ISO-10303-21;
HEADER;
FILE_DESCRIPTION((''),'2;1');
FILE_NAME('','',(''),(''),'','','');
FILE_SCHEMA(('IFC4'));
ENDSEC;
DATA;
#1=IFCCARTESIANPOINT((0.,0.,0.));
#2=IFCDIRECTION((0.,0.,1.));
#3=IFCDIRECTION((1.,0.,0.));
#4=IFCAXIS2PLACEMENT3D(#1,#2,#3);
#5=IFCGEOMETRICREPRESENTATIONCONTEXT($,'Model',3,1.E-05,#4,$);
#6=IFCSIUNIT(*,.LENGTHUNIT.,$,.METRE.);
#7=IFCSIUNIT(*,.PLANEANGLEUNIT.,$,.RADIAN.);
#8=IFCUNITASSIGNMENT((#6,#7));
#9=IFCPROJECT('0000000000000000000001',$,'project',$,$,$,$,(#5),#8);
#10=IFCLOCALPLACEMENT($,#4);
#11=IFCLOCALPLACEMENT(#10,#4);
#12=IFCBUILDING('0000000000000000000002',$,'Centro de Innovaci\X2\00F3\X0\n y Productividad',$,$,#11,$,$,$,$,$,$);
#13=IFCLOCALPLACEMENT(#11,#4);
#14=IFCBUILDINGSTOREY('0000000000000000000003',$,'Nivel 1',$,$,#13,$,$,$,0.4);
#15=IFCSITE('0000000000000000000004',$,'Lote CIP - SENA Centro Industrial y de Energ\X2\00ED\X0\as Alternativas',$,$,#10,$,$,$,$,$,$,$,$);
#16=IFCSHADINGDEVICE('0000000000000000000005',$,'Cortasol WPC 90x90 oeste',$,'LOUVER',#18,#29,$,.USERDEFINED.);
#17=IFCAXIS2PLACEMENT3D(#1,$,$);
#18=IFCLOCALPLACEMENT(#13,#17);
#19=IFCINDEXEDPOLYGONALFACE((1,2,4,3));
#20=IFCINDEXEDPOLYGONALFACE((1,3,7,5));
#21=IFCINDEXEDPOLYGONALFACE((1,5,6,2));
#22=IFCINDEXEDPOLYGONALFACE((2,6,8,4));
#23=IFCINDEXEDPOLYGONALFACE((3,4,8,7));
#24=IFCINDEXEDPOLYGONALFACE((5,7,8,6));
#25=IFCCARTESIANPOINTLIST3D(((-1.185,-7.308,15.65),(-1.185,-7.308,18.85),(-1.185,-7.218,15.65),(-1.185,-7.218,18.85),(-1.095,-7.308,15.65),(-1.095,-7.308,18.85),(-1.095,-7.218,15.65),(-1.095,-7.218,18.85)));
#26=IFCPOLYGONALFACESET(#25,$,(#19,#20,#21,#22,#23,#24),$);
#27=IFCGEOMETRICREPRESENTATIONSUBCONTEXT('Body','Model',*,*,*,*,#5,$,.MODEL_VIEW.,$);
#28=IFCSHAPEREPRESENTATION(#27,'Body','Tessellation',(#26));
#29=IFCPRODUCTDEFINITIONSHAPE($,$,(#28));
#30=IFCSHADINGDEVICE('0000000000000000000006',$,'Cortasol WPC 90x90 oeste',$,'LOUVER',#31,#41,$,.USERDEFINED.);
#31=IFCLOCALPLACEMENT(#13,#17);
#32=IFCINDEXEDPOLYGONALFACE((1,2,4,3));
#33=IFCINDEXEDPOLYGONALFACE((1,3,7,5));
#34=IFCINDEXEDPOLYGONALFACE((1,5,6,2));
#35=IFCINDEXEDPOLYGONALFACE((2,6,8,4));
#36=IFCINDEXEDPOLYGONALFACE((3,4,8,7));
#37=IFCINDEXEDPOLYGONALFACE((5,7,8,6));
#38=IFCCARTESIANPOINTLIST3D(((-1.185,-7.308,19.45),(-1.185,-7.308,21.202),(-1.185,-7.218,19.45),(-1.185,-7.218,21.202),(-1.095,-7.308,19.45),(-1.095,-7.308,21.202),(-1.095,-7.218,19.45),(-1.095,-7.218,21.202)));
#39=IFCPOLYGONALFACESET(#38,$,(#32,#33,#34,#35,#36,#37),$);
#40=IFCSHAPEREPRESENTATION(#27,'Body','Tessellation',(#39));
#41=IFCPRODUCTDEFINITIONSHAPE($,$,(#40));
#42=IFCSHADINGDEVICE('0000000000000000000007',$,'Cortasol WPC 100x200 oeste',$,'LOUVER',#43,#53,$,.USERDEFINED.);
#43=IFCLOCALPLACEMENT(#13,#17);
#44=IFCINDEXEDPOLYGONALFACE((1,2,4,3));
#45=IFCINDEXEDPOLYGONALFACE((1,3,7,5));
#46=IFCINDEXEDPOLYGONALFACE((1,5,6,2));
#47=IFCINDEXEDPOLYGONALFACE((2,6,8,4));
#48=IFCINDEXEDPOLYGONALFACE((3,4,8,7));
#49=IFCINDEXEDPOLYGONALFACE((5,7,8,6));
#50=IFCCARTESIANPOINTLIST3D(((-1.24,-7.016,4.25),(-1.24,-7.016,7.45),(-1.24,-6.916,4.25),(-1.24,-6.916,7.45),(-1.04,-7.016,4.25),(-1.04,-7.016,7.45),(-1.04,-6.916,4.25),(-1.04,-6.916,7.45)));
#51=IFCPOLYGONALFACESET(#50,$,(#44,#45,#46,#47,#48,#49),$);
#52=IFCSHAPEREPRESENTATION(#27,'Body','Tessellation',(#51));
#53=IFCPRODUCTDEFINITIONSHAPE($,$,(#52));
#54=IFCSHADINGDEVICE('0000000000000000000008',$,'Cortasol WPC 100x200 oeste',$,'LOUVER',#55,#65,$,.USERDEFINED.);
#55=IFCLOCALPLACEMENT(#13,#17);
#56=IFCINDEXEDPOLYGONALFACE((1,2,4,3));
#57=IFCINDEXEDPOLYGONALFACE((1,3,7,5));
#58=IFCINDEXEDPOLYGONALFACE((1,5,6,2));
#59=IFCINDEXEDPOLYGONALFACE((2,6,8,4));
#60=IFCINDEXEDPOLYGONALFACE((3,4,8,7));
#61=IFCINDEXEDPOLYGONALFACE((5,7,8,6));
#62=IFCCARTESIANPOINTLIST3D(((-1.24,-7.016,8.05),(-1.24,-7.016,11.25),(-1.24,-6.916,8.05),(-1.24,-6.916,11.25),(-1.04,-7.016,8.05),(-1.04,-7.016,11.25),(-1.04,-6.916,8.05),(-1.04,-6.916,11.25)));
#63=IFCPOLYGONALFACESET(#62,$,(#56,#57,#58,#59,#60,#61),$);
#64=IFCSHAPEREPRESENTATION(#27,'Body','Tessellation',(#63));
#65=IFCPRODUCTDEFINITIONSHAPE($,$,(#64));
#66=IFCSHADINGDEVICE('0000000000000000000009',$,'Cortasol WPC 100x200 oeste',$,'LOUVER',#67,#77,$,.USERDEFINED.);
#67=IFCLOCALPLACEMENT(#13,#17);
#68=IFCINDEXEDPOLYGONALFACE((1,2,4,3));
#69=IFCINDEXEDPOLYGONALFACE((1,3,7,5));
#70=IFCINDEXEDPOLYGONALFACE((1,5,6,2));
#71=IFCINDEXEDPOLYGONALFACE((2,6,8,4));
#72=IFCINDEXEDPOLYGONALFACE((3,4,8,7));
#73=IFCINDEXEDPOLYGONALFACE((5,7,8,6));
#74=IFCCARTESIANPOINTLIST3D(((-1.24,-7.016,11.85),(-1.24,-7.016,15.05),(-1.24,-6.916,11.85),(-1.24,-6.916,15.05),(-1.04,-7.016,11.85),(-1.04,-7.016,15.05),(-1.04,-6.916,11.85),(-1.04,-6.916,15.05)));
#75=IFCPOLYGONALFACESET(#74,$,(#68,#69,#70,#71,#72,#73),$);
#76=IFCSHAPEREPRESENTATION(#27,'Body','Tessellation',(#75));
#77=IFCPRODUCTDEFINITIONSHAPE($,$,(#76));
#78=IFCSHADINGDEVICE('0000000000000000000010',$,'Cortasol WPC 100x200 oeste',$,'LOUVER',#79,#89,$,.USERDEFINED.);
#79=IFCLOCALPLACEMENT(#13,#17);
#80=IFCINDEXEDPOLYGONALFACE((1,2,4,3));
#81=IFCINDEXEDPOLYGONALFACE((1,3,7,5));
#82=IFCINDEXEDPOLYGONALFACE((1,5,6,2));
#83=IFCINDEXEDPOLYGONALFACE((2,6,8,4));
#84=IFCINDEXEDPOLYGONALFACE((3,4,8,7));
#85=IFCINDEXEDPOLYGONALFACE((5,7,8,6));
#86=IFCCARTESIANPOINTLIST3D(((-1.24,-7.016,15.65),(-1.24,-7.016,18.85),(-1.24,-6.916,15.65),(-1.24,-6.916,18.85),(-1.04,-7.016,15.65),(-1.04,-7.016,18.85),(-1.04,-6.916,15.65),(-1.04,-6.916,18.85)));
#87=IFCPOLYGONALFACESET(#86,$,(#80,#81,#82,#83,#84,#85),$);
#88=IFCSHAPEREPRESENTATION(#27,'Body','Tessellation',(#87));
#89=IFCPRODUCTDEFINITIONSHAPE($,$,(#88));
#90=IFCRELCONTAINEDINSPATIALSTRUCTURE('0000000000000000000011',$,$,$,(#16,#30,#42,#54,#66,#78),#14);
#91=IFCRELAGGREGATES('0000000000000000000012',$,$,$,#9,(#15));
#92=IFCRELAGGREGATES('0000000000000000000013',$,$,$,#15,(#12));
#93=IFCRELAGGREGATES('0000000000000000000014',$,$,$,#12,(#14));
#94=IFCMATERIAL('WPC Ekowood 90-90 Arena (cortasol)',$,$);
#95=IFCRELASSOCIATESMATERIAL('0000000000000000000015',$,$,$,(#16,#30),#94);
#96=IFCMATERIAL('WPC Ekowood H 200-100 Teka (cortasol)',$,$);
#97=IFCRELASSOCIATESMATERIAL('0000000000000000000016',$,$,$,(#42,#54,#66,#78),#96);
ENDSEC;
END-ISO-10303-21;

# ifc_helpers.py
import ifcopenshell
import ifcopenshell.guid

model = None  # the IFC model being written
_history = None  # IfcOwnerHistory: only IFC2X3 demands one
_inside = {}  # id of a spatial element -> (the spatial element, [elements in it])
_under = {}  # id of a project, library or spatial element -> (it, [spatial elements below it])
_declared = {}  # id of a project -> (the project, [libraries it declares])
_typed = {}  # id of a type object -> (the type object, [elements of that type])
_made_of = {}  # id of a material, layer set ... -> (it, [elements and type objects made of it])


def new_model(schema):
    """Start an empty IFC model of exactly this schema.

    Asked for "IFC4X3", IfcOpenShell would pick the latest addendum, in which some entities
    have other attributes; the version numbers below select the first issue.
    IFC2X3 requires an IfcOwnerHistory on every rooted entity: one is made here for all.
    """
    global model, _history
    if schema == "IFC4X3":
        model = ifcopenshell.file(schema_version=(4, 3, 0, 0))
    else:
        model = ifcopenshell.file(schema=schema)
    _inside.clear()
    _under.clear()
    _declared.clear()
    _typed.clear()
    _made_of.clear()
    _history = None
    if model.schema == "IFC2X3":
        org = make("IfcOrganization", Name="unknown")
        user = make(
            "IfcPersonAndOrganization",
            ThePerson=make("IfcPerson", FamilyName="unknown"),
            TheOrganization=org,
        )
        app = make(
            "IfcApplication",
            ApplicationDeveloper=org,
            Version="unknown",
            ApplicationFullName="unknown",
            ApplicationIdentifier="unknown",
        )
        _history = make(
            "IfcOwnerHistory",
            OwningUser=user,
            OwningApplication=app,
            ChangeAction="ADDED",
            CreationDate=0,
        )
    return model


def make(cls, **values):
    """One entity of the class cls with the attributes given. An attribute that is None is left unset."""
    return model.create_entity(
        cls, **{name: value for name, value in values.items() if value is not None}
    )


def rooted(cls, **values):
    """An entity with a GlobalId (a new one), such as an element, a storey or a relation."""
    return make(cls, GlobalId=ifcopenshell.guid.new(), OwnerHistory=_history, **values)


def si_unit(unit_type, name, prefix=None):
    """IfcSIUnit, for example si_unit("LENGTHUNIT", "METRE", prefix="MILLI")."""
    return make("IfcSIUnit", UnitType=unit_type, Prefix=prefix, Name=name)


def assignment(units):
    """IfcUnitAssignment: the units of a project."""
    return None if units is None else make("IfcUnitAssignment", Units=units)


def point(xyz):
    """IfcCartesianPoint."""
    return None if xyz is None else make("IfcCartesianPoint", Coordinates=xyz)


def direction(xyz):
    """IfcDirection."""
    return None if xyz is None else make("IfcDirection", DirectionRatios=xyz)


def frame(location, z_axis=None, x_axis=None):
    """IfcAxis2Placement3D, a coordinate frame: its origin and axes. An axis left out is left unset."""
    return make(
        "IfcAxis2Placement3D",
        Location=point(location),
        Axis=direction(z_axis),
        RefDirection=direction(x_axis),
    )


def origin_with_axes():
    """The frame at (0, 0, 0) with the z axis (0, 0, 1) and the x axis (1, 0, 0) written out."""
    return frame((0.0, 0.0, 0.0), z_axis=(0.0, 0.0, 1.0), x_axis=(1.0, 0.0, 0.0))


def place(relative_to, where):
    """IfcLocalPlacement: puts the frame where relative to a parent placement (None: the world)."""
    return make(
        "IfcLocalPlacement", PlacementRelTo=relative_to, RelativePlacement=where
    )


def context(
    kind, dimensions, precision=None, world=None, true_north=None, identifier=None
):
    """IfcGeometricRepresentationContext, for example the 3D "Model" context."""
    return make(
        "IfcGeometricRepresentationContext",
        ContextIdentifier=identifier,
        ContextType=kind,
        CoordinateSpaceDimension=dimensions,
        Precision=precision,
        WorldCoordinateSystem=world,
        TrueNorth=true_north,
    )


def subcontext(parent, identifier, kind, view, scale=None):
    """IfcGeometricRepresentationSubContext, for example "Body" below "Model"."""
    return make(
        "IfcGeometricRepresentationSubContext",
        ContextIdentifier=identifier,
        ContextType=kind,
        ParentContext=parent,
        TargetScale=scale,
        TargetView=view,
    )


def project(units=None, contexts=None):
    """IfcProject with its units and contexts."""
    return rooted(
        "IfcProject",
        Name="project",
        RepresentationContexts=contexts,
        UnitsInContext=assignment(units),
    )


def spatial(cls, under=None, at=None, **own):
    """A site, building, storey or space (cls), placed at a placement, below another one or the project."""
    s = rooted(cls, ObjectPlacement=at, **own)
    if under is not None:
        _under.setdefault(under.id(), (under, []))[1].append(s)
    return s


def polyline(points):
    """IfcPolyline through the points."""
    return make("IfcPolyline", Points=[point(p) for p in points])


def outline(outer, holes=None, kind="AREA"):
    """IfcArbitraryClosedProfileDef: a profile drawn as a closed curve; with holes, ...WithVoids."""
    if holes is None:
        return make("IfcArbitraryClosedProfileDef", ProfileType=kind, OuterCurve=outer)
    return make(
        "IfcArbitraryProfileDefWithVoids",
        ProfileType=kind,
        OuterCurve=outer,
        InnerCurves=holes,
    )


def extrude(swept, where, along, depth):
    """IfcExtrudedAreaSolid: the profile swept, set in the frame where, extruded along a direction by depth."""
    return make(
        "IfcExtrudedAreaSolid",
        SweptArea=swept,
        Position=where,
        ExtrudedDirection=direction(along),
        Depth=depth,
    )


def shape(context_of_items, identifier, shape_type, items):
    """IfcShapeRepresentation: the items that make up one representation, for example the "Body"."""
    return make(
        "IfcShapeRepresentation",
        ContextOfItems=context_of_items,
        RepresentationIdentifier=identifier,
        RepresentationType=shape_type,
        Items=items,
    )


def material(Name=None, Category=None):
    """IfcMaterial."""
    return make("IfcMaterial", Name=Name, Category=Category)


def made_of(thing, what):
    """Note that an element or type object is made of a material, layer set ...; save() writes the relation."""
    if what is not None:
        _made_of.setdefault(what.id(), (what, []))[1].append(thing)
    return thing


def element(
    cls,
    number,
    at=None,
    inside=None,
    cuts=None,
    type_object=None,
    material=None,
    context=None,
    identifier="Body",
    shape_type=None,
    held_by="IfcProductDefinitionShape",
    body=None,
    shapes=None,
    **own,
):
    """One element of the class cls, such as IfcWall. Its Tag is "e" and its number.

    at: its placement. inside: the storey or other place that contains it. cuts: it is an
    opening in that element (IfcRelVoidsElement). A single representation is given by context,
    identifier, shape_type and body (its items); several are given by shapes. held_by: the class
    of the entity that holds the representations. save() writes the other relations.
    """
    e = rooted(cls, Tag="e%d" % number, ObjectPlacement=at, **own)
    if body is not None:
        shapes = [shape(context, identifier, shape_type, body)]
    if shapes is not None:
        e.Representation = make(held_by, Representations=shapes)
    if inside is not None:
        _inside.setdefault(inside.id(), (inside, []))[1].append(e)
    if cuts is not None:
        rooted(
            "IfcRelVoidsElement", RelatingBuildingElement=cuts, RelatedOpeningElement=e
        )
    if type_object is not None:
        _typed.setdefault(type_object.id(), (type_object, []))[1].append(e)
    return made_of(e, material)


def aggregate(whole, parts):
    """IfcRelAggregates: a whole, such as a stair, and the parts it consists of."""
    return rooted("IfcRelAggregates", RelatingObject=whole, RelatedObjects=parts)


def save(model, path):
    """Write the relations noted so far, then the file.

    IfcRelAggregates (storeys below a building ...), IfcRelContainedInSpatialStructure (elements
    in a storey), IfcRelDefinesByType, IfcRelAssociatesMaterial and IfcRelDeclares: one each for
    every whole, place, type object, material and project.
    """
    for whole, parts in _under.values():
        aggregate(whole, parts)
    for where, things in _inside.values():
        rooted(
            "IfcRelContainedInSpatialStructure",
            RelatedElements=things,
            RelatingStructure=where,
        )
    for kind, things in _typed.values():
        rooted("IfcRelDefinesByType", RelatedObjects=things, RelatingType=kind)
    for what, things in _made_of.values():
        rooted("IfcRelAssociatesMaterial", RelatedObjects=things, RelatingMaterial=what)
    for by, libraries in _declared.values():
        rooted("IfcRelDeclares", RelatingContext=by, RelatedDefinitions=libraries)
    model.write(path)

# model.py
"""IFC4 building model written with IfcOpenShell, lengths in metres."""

from ifc_helpers import new_model, si_unit, frame, origin_with_axes, place, context, subcontext, project, spatial, polyline, outline, extrude, material, element, save


model = new_model("IFC4")

# Units and contexts
model_context = context("Model", 3, precision=1e-05, world=origin_with_axes())
body_context = subcontext(model_context, "Body", "Model", "MODEL_VIEW")
ifc_project = project(units=[si_unit("LENGTHUNIT", "METRE"), si_unit("PLANEANGLEUNIT", "RADIAN")], contexts=[model_context])

# Site, building, storey
site_placement = place(None, origin_with_axes())
site = spatial("IfcSite", under=ifc_project, at=site_placement, Name="Lote CIP - SENA Centro Industrial y de Energías Alternativas")
building_placement = place(site_placement, origin_with_axes())
building = spatial("IfcBuilding", under=site, at=building_placement, Name="Centro de Innovación y Productividad")
storey_placement = place(building_placement, origin_with_axes())
storey = spatial("IfcBuildingStorey", under=building, at=storey_placement, Name="Nivel 1", Elevation=0.4)

# Shading devices
ifc_material_1 = material(Name="WPC Ekowood H 200-100 Teka (cortasol)")
ifc_material_2 = material(Name="WPC Ekowood 90-90 Arena (cortasol)")
shading_device_1_placement = place(storey_placement, origin_with_axes())
element("IfcShadingDevice", 1, at=shading_device_1_placement, inside=storey, material=ifc_material_2, Name="Cortasol WPC 90x90 oeste", ObjectType="LOUVER", PredefinedType="USERDEFINED", context=body_context, shape_type="SweptSolid", body=[
    extrude(outline(polyline([(-1.095, -7.308), (-1.185, -7.308), (-1.185, -7.218), (-1.095, -7.218), (-1.095, -7.308)])), frame((0.0, 0.0, 15.65)), (0.0, 0.0, 1.0), 3.2),
])
shading_device_2_placement = place(storey_placement, origin_with_axes())
element("IfcShadingDevice", 2, at=shading_device_2_placement, inside=storey, material=ifc_material_2, Name="Cortasol WPC 90x90 oeste", ObjectType="LOUVER", PredefinedType="USERDEFINED", context=body_context, shape_type="SweptSolid", body=[
    extrude(outline(polyline([(-1.095, -7.308), (-1.185, -7.308), (-1.185, -7.218), (-1.095, -7.218), (-1.095, -7.308)])), frame((0.0, 0.0, 19.45)), (0.0, 0.0, 1.0), 1.752),
])
shading_device_3_placement = place(storey_placement, origin_with_axes())
element("IfcShadingDevice", 3, at=shading_device_3_placement, inside=storey, material=ifc_material_1, Name="Cortasol WPC 100x200 oeste", ObjectType="LOUVER", PredefinedType="USERDEFINED", context=body_context, shape_type="SweptSolid", body=[
    extrude(outline(polyline([(-1.04, -7.016), (-1.24, -7.016), (-1.24, -6.916), (-1.04, -6.916), (-1.04, -7.016)])), frame((0.0, 0.0, 4.25)), (0.0, 0.0, 1.0), 3.2),
])
shading_device_4_placement = place(storey_placement, origin_with_axes())
element("IfcShadingDevice", 4, at=shading_device_4_placement, inside=storey, material=ifc_material_1, Name="Cortasol WPC 100x200 oeste", ObjectType="LOUVER", PredefinedType="USERDEFINED", context=body_context, shape_type="SweptSolid", body=[
    extrude(outline(polyline([(-1.04, -7.016), (-1.24, -7.016), (-1.24, -6.916), (-1.04, -6.916), (-1.04, -7.016)])), frame((0.0, 0.0, 8.05)), (0.0, 0.0, 1.0), 3.2),
])
shading_device_5_placement = place(storey_placement, origin_with_axes())
element("IfcShadingDevice", 5, at=shading_device_5_placement, inside=storey, material=ifc_material_1, Name="Cortasol WPC 100x200 oeste", ObjectType="LOUVER", PredefinedType="USERDEFINED", context=body_context, shape_type="SweptSolid", body=[
    extrude(outline(polyline([(-1.04, -7.016), (-1.24, -7.016), (-1.24, -6.916), (-1.04, -6.916), (-1.04, -7.016)])), frame((0.0, 0.0, 11.85)), (0.0, 0.0, 1.0), 3.2),
])
shading_device_6_placement = place(storey_placement, origin_with_axes())
element("IfcShadingDevice", 6, at=shading_device_6_placement, inside=storey, material=ifc_material_1, Name="Cortasol WPC 100x200 oeste", ObjectType="LOUVER", PredefinedType="USERDEFINED", context=body_context, shape_type="SweptSolid", body=[
    extrude(outline(polyline([(-1.04, -7.016), (-1.24, -7.016), (-1.24, -6.916), (-1.04, -6.916), (-1.04, -7.016)])), frame((0.0, 0.0, 15.65)), (0.0, 0.0, 1.0), 3.2),
])

save(model, "model.ifc")
